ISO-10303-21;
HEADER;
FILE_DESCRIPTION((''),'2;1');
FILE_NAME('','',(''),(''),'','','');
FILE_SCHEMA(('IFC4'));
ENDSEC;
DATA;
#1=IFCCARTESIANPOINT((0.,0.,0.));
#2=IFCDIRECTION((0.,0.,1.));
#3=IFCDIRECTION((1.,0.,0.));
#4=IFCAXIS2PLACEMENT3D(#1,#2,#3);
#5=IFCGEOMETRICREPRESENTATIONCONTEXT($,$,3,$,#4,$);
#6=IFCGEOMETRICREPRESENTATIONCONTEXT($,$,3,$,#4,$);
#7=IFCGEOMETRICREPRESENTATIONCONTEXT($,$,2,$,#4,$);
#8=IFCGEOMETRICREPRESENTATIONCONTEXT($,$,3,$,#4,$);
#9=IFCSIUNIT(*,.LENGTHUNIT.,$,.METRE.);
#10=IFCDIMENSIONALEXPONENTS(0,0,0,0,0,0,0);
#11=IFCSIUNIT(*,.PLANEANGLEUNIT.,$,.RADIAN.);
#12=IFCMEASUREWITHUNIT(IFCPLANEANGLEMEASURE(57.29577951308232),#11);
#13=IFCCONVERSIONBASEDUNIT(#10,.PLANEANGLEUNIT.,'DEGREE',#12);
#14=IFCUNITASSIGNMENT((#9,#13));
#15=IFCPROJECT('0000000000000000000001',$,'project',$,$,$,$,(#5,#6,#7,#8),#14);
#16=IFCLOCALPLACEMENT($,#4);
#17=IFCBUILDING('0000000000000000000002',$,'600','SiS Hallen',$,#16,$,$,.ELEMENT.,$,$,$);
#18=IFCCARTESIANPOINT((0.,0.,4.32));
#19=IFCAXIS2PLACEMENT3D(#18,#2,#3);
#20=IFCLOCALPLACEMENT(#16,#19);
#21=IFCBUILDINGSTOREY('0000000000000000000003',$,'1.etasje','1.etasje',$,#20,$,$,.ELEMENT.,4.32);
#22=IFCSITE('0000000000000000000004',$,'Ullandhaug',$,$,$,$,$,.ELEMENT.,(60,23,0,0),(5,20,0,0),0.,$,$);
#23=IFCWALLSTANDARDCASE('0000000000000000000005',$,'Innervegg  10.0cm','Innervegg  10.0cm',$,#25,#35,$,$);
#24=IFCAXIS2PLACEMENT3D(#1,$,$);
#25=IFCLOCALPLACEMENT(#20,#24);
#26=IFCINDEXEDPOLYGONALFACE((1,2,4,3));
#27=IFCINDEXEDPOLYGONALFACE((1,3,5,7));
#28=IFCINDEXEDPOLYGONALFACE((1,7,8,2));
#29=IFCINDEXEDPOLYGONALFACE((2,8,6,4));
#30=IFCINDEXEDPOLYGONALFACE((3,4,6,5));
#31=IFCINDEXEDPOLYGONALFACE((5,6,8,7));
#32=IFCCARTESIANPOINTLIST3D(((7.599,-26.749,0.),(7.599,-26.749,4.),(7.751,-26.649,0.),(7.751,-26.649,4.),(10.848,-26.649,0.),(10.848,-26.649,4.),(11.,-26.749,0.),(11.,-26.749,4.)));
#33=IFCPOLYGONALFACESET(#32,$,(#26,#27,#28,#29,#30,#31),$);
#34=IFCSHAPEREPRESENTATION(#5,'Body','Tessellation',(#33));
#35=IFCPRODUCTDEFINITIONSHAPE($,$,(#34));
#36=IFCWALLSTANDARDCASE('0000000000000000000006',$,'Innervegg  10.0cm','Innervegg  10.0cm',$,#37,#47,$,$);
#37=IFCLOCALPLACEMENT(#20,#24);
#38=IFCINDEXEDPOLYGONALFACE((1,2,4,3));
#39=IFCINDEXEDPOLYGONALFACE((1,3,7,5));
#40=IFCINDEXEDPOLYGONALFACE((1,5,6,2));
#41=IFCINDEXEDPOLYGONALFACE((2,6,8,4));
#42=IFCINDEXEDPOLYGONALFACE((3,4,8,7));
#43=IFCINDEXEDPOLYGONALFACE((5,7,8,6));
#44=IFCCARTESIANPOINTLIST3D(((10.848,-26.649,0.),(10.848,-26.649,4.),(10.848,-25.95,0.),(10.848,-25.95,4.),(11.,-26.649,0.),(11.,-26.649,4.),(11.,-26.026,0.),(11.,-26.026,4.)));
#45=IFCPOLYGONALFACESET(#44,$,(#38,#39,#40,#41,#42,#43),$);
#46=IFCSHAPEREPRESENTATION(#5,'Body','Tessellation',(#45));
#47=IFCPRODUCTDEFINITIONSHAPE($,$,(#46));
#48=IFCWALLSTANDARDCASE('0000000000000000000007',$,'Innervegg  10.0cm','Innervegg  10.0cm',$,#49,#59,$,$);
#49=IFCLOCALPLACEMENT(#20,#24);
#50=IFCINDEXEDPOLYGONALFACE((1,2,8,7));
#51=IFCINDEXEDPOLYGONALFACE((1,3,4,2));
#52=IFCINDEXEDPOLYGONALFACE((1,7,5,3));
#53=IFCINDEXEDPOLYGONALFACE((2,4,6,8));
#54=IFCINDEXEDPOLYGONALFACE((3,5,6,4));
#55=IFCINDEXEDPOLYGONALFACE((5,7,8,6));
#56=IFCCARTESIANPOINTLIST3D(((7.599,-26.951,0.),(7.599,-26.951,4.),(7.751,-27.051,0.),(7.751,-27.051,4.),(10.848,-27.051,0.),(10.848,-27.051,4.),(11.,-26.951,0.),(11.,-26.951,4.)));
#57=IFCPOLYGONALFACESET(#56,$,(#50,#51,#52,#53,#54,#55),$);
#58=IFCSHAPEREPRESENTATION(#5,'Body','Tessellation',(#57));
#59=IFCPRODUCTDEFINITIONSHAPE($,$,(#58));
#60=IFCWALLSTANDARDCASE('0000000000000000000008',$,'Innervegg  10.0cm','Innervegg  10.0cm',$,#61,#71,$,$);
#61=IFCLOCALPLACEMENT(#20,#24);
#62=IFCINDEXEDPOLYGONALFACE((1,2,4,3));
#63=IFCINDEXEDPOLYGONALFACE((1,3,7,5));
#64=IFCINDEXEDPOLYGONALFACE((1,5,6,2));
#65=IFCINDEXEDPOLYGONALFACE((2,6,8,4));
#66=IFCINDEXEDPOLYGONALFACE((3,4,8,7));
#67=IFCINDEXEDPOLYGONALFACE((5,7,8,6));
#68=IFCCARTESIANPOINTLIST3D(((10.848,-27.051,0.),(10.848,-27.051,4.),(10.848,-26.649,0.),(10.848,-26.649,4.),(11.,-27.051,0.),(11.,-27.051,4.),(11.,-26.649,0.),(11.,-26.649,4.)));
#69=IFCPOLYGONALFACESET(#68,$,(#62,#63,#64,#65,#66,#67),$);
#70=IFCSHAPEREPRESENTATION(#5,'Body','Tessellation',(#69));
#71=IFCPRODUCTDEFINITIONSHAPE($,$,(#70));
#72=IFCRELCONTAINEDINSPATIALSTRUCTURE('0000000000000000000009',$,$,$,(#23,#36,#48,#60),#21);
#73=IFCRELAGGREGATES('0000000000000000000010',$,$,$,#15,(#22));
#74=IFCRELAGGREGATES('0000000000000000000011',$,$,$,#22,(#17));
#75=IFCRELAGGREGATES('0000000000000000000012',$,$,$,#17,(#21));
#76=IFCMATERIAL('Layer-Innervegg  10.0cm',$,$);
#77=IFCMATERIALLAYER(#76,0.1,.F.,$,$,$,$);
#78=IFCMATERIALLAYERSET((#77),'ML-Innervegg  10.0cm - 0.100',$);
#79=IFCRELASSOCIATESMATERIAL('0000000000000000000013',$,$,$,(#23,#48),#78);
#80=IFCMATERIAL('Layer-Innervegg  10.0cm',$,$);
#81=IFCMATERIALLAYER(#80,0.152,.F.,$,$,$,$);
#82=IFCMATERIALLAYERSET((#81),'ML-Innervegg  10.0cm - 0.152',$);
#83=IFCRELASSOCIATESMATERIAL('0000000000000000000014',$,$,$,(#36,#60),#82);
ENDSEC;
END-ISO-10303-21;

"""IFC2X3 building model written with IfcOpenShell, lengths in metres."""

from ifc_helpers import new_model, entity, si_unit, converted_unit, frame, origin_with_axes, place, context, project, spatial, polyline, outline, extrude, material, layer, layer_set, layer_usage, element, save


model = new_model("IFC2X3")

# Units and contexts
context_of_model_1 = context(None, 3, world=origin_with_axes())
context_of_model_2 = context(None, 3, world=origin_with_axes())
context_of_model_3 = context(None, 2, world=origin_with_axes())
context_of_model_4 = context(None, 3, world=origin_with_axes())
ifc_project = project(units=[si_unit("LENGTHUNIT", "METRE"), converted_unit("PLANEANGLEUNIT", "DEGREE", entity("IfcPlaneAngleMeasure", 57.29577951308232), si_unit("PLANEANGLEUNIT", "RADIAN"), dimensions=[0, 0, 0, 0, 0, 0, 0])], contexts=[context_of_model_1, context_of_model_2, context_of_model_3, context_of_model_4])

# Site, building, storey
site = spatial("IfcSite", under=ifc_project, Name="Ullandhaug", CompositionType="ELEMENT", RefLatitude=(60, 23, 0, 0), RefLongitude=(5, 20, 0, 0), RefElevation=0.0)
building_placement = place(None, origin_with_axes())
building = spatial("IfcBuilding", under=site, at=building_placement, Name="600", Description="SiS Hallen", CompositionType="ELEMENT")
storey_placement = place(building_placement, frame((0.0, 0.0, 4.32), z_axis=(0.0, 0.0, 1.0), x_axis=(1.0, 0.0, 0.0)))
storey = spatial("IfcBuildingStorey", under=building, at=storey_placement, Name="1.etasje", Description="1.etasje", CompositionType="ELEMENT", Elevation=4.32)

# Shared definitions
ifc_material_1 = material(Name="Layer-Innervegg  10.0cm")
ifc_layer_1 = layer(ifc_material_1, 0.152, ventilated=False)
ifc_layer_set_1 = layer_set([ifc_layer_1], Name="ML-Innervegg  10.0cm - 0.152")
ifc_layer_usage_1 = layer_usage(ifc_layer_set_1, "AXIS2", "POSITIVE", 0.0)

# Walls
ifc_material_2 = material(Name="Layer-Innervegg  10.0cm")
ifc_layer_2 = layer(ifc_material_2, 0.1, ventilated=False)
ifc_layer_set_2 = layer_set([ifc_layer_2], Name="ML-Innervegg  10.0cm - 0.100")
ifc_layer_usage_2 = layer_usage(ifc_layer_set_2, "AXIS2", "POSITIVE", 0.0)
wall_1_placement = place(storey_placement, frame((7.599, -26.749, 0.0), z_axis=(0.0, 0.0, 1.0), x_axis=(1.0, 0.0, 0.0)))
element("IfcWallStandardCase", 1, at=wall_1_placement, inside=storey, material=ifc_layer_usage_2, Name="Innervegg  10.0cm", Description="Innervegg  10.0cm", context=context_of_model_1, shape_type="SweptSolid", body=[
    extrude(outline(polyline([(0.0, 0.0), (3.401, 0.0), (3.249, 0.1), (0.152, 0.1), (0.0, 0.0)])), origin_with_axes(), (0.0, 0.0, 1.0), 4.0),
])
wall_2_placement = place(storey_placement, frame((11.0, -26.649, 0.0), z_axis=(0.0, 0.0, 1.0), x_axis=(0.0, 1.0, 0.0)))
element("IfcWallStandardCase", 2, at=wall_2_placement, inside=storey, material=ifc_layer_usage_1, Name="Innervegg  10.0cm", Description="Innervegg  10.0cm", context=context_of_model_1, shape_type="SweptSolid", body=[
    extrude(outline(polyline([(0.0, 0.0), (0.623, 0.0), (0.699, 0.152), (0.0, 0.152), (0.0, 0.0)])), frame((0.0, 0.0, 0.0), z_axis=(0.0, 0.0, 1.0), x_axis=(1.0, 0.0, 0.0)), (0.0, 0.0, 1.0), 4.0),
])
wall_3_placement = place(storey_placement, frame((11.0, -26.951, 0.0), z_axis=(0.0, 0.0, 1.0), x_axis=(-1.0, 0.0, 0.0)))
element("IfcWallStandardCase", 3, at=wall_3_placement, inside=storey, material=ifc_layer_usage_2, Name="Innervegg  10.0cm", Description="Innervegg  10.0cm", context=context_of_model_1, shape_type="SweptSolid", body=[
    extrude(outline(polyline([(0.0, 0.0), (3.401, 0.0), (3.249, 0.1), (0.152, 0.1), (0.0, 0.0)])), frame((0.0, 0.0, 0.0), z_axis=(0.0, 0.0, 1.0), x_axis=(1.0, 0.0, 0.0)), (0.0, 0.0, 1.0), 4.0),
])
wall_4_placement = place(storey_placement, frame((10.848, -26.649, 0.0), z_axis=(0.0, 0.0, 1.0), x_axis=(0.0, -1.0, 0.0)))
element("IfcWallStandardCase", 4, at=wall_4_placement, inside=storey, material=ifc_layer_usage_1, Name="Innervegg  10.0cm", Description="Innervegg  10.0cm", context=context_of_model_1, shape_type="SweptSolid", body=[
    extrude(outline(polyline([(0.0, 0.0), (0.402, 0.0), (0.402, 0.152), (0.0, 0.152), (0.0, 0.0)])), frame((0.0, 0.0, 0.0), z_axis=(0.0, 0.0, 1.0), x_axis=(1.0, 0.0, 0.0)), (0.0, 0.0, 1.0), 4.0),
])

save(model, "model.ifc")
